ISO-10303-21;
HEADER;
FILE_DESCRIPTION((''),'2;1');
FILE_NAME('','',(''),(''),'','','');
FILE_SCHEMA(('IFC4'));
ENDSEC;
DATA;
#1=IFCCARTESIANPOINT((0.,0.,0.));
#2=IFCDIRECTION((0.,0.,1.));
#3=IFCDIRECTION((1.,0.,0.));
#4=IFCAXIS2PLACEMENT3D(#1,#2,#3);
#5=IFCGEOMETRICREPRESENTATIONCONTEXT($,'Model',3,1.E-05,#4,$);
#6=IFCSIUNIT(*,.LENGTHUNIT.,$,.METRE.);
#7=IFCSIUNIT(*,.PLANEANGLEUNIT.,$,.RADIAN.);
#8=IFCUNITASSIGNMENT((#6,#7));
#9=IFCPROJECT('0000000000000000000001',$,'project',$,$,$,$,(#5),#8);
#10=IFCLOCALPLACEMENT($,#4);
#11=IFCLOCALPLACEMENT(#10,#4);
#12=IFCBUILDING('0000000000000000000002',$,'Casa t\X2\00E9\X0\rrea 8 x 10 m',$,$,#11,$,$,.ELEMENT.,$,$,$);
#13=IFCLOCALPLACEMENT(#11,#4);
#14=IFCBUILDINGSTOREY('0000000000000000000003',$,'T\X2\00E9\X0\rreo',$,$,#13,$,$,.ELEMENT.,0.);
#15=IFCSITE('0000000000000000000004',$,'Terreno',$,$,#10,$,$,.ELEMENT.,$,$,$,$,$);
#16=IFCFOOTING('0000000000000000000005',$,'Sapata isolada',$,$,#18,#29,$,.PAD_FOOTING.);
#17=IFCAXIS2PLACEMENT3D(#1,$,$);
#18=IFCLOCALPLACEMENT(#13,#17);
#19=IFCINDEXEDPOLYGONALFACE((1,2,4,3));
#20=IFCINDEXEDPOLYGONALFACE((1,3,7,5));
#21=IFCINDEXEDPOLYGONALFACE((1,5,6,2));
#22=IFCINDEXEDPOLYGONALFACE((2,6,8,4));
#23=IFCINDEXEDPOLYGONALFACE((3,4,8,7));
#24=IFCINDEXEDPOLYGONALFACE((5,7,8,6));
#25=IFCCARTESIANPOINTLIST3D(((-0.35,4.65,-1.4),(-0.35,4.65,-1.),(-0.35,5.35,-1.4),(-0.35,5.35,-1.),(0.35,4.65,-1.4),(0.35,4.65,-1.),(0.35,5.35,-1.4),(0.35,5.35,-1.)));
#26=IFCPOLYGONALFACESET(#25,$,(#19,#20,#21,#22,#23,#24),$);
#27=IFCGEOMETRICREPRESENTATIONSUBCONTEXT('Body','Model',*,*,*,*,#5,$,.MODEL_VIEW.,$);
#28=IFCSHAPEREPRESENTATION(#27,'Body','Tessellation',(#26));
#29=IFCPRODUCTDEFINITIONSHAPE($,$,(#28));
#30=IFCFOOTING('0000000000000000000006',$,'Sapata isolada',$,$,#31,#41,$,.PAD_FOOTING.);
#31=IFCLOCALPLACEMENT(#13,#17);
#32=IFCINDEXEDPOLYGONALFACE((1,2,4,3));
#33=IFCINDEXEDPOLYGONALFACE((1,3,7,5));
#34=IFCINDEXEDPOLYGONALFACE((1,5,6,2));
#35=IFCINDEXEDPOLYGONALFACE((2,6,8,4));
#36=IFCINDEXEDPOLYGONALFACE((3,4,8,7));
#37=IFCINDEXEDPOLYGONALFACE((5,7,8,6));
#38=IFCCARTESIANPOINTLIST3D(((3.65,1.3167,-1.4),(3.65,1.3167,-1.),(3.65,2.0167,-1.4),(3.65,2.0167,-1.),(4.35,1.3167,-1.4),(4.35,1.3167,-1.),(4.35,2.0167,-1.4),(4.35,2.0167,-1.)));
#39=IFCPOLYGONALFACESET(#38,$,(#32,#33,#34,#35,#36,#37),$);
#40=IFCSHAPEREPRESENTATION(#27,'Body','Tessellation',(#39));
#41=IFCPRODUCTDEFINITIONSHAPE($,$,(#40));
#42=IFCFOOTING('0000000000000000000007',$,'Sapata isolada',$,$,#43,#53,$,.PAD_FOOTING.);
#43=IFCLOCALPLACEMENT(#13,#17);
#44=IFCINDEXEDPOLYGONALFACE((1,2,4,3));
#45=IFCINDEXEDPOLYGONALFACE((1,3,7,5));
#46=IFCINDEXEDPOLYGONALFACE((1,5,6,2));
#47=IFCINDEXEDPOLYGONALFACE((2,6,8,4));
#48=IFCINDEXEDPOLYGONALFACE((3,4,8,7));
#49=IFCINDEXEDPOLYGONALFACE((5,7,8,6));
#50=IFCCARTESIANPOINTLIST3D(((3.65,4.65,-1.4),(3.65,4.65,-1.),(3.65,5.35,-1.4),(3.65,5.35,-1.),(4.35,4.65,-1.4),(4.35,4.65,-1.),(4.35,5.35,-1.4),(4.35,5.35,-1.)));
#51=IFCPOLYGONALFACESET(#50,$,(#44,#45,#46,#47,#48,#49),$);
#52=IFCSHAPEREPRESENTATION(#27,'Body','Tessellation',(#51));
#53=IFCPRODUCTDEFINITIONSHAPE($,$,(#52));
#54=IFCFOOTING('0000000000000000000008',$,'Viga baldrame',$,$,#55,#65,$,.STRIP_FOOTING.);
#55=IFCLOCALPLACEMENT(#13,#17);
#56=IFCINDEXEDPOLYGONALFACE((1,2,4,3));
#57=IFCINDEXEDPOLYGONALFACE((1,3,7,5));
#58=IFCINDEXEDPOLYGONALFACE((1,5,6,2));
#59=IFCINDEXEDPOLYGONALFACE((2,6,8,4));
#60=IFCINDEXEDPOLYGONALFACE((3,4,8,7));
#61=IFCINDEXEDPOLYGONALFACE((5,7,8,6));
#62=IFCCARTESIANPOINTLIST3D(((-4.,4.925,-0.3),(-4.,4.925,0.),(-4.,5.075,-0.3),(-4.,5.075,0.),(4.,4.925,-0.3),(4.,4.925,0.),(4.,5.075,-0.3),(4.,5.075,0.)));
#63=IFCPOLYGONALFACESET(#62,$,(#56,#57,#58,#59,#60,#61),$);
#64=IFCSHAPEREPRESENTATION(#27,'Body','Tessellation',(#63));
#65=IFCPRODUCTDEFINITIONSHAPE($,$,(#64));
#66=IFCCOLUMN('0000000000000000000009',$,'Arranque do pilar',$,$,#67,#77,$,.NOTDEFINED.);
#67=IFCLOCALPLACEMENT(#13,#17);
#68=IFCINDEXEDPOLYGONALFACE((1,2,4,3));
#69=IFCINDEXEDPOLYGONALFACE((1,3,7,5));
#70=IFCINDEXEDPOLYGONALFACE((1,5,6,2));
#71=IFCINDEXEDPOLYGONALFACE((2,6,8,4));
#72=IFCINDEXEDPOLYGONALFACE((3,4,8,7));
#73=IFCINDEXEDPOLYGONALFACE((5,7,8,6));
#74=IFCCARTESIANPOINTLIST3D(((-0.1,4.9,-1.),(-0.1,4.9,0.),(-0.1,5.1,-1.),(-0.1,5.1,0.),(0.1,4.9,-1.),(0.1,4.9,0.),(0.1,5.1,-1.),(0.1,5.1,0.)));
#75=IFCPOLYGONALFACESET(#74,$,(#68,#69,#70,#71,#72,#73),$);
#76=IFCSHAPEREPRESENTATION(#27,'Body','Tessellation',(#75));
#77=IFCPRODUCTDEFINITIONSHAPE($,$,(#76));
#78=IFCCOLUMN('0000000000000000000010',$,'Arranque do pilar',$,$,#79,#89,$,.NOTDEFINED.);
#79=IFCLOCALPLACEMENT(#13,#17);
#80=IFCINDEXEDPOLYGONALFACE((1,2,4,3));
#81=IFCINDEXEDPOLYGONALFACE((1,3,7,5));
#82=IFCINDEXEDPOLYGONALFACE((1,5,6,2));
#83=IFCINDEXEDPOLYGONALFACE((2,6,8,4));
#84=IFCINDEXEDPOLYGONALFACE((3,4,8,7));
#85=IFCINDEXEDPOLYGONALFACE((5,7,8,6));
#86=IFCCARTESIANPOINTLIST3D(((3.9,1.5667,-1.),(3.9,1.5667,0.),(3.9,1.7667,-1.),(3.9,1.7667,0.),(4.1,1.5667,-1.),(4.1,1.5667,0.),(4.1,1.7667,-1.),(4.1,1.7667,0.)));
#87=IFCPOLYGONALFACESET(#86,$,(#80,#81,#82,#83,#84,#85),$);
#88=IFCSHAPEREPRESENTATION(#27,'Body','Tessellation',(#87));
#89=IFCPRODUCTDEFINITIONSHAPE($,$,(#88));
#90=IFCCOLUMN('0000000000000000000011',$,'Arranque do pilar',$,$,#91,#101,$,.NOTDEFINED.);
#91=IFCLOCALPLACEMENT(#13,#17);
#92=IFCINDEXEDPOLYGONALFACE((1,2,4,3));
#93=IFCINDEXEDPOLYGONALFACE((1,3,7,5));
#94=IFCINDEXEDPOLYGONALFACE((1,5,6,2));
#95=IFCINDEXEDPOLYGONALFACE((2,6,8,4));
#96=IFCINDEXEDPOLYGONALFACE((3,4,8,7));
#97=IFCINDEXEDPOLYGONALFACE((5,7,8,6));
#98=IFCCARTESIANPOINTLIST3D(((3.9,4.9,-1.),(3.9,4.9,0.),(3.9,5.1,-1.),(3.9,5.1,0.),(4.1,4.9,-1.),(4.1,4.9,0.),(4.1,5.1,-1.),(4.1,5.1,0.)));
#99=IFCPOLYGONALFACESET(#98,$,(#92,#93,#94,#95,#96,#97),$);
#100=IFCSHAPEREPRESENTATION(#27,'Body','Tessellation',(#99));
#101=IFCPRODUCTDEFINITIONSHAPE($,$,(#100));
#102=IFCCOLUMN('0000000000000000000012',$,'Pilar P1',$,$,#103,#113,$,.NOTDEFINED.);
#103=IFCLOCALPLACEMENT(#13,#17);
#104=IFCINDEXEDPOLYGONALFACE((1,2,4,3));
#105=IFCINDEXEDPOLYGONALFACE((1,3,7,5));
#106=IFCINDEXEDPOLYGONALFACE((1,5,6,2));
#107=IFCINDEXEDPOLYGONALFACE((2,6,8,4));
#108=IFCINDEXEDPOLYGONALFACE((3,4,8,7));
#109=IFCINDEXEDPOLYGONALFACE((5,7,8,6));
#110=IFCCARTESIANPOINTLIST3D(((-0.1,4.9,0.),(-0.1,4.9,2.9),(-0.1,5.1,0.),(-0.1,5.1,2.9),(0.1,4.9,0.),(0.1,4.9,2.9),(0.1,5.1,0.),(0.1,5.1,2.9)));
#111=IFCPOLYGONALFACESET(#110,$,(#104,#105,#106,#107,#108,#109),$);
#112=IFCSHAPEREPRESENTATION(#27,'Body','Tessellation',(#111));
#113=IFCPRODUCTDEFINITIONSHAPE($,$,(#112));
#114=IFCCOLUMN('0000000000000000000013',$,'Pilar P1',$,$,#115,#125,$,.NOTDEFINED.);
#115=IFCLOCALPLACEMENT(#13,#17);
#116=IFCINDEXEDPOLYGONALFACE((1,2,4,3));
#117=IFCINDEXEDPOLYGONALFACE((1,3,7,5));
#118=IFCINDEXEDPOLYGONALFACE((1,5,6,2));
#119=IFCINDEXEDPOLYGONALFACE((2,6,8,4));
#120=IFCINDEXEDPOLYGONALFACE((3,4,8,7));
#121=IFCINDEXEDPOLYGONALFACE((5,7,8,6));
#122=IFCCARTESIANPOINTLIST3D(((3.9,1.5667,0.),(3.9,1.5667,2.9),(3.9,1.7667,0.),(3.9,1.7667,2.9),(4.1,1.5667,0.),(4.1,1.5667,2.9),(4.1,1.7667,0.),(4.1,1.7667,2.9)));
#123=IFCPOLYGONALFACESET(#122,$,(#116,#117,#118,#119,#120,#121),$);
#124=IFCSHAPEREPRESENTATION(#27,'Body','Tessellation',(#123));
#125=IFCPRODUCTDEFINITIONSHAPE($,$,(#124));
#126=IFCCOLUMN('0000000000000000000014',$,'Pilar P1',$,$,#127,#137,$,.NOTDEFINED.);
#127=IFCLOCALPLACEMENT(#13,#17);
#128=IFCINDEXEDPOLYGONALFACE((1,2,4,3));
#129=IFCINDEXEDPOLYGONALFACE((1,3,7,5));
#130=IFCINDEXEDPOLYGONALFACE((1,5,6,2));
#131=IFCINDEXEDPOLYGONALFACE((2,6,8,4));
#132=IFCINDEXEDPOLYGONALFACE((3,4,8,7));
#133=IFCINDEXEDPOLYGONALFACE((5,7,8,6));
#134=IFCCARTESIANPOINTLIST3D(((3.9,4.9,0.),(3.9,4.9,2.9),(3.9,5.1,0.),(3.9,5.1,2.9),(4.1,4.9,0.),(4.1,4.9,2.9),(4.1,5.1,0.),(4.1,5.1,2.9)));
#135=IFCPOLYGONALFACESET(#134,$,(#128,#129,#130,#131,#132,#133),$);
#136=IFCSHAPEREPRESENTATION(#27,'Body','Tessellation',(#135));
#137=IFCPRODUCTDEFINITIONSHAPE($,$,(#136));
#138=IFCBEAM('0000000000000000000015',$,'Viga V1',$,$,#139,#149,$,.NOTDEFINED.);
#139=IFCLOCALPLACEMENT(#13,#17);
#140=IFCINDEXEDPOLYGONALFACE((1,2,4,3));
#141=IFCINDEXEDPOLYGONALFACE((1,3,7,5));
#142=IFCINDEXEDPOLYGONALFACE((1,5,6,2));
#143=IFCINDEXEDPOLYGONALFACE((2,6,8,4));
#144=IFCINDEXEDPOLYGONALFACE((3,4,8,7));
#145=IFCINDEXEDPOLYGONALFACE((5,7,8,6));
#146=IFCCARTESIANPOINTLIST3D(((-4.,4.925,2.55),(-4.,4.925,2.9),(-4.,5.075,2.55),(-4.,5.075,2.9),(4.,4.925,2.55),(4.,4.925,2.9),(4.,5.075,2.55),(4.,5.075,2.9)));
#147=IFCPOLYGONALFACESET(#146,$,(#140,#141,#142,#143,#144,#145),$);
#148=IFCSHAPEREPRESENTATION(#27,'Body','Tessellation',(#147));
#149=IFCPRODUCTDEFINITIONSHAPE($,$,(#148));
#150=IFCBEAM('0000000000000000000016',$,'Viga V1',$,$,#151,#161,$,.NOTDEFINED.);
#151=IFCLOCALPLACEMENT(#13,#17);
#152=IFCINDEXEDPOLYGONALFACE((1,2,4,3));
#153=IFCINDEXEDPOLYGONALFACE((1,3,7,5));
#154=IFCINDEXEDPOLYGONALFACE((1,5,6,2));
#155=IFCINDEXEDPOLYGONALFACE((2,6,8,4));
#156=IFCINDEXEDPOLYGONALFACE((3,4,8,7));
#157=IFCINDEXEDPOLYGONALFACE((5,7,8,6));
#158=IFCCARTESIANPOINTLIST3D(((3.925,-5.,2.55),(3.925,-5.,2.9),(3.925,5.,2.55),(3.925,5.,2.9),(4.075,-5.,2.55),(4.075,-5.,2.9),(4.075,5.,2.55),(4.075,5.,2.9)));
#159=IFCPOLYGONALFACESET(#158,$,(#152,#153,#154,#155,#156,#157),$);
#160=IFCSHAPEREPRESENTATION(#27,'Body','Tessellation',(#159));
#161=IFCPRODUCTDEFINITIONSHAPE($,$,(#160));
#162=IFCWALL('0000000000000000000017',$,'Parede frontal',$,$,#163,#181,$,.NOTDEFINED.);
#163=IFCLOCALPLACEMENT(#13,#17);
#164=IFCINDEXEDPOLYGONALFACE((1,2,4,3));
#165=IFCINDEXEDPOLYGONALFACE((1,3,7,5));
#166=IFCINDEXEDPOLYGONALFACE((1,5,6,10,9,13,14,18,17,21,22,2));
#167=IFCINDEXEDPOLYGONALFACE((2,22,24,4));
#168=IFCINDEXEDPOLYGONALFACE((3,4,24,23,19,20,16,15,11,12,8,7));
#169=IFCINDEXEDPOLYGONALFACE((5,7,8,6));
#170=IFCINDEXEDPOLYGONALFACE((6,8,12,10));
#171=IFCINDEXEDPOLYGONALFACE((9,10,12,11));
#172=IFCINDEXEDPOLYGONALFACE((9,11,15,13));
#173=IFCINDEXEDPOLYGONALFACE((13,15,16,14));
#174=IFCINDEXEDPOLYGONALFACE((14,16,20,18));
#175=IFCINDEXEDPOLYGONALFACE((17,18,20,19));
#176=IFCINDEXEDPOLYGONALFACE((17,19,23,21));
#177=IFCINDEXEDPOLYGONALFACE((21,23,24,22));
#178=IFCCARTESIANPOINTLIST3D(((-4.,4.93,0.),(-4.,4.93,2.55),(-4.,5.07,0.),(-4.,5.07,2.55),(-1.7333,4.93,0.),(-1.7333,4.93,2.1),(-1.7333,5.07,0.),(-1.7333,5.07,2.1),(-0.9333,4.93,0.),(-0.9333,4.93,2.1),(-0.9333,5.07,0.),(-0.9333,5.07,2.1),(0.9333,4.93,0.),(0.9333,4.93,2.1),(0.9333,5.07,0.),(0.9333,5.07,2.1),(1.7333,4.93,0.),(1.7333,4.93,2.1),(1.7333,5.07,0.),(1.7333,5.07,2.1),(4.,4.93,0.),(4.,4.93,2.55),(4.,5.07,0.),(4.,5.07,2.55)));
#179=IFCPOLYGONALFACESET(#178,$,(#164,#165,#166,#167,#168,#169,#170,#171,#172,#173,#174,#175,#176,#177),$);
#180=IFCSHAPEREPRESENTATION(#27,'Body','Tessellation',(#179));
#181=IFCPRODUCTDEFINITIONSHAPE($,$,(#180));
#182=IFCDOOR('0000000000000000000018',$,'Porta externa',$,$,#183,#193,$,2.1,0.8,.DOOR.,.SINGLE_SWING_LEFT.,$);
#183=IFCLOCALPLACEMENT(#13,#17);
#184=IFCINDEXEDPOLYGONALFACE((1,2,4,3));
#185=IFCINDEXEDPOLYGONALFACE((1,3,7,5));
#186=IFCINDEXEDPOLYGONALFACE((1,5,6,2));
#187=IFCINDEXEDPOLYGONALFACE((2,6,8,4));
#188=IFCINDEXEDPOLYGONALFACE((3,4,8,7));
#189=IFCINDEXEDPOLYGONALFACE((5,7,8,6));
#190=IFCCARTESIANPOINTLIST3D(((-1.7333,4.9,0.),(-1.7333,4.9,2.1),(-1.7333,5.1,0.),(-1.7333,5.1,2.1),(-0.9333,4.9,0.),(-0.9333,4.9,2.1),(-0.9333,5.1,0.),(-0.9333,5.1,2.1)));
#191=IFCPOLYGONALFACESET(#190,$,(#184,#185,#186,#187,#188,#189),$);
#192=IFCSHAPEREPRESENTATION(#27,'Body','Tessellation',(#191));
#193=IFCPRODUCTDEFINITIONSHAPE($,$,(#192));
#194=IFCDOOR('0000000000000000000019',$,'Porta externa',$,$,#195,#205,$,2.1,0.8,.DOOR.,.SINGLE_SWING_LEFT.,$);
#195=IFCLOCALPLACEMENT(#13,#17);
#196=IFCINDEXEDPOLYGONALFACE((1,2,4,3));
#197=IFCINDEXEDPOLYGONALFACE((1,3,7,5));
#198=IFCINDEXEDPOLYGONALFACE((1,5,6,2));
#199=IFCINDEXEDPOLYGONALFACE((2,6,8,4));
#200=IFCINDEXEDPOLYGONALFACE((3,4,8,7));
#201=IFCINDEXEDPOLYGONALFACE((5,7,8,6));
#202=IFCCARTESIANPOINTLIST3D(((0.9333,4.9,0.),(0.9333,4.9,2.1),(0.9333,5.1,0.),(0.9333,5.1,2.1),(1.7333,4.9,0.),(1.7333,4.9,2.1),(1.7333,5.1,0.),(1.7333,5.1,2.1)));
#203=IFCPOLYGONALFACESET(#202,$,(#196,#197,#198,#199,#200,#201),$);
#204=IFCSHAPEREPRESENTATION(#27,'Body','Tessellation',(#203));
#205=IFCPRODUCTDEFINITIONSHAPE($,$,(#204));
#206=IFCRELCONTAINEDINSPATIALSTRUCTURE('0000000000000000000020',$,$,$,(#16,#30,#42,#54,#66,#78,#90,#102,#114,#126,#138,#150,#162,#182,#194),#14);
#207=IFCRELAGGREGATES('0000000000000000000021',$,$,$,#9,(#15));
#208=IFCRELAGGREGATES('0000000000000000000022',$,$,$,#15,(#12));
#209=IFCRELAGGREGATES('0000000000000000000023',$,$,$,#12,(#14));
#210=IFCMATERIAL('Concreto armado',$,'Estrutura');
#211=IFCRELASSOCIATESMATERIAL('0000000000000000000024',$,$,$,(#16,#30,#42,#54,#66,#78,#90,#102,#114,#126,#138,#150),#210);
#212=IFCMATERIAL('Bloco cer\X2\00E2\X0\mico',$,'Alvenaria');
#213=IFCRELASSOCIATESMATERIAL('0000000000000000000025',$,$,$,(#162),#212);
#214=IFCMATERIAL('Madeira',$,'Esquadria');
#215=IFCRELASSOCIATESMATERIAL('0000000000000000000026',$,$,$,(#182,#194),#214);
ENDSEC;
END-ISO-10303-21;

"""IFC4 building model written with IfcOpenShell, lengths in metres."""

from ifc_helpers import new_model, si_unit, frame, origin_with_axes, origin_2d, place, context, subcontext, project, spatial, rectangle, extrude, material, element, fill, save


model = new_model("IFC4")

# Units and contexts
model_context = context("Model", 3, precision=1e-05, world=origin_with_axes())
body_context = subcontext(model_context, "Body", "Model", "MODEL_VIEW")
ifc_project = project(units=[si_unit("LENGTHUNIT", "METRE"), si_unit("PLANEANGLEUNIT", "RADIAN")], contexts=[model_context])

# Site, building, storey
site_placement = place(None, origin_with_axes())
site = spatial("IfcSite", under=ifc_project, at=site_placement, Name="Terreno", CompositionType="ELEMENT")
building_placement = place(site_placement, origin_with_axes())
building = spatial("IfcBuilding", under=site, at=building_placement, Name="Casa térrea 8 x 10 m", CompositionType="ELEMENT")
storey_placement = place(building_placement, origin_with_axes())
storey = spatial("IfcBuildingStorey", under=building, at=storey_placement, Name="Térreo", CompositionType="ELEMENT", Elevation=0.0)

# Footings
ifc_material_1 = material(Name="Concreto armado", Category="Estrutura")
for number, where, z_axis, x_axis, name in (
    (1, (0.0, 5.0, -1.4), (0.0, 0.0, 1.0), (1.0, 0.0, 0.0), "Sapata isolada"),
    (2, (4.0, 1.6667, -1.4), (0.0, 0.0, 1.0), (1.0, 0.0, 0.0), "Sapata isolada"),
    (3, (4.0, 5.0, -1.4), (0.0, 0.0, 1.0), (1.0, 0.0, 0.0), "Sapata isolada"),
):
    element("IfcFooting", number, at=place(storey_placement, frame(where, z_axis=z_axis, x_axis=x_axis)), inside=storey, material=ifc_material_1, Name=name, PredefinedType="PAD_FOOTING", context=body_context, shape_type="SweptSolid", body=[
        extrude(rectangle(XDim=0.7, YDim=0.7, at=origin_2d()), None, (0.0, 0.0, 1.0), 0.4),
    ])
footing_placement = place(storey_placement, frame((0.0, 5.0, -0.3), z_axis=(0.0, 0.0, 1.0), x_axis=(1.0, 0.0, 0.0)))
element("IfcFooting", 4, at=footing_placement, inside=storey, material=ifc_material_1, Name="Viga baldrame", PredefinedType="STRIP_FOOTING", context=body_context, shape_type="SweptSolid", body=[
    extrude(rectangle(XDim=8.0, YDim=0.15, at=origin_2d()), None, (0.0, 0.0, 1.0), 0.3),
])

# Columns
for number, where, z_axis, x_axis, name in (
    (5, (0.0, 5.0, -1.0), (0.0, 0.0, 1.0), (1.0, 0.0, 0.0), "Arranque do pilar"),
    (6, (4.0, 1.6667, -1.0), (0.0, 0.0, 1.0), (1.0, 0.0, 0.0), "Arranque do pilar"),
    (7, (4.0, 5.0, -1.0), (0.0, 0.0, 1.0), (1.0, 0.0, 0.0), "Arranque do pilar"),
):
    element("IfcColumn", number, at=place(storey_placement, frame(where, z_axis=z_axis, x_axis=x_axis)), inside=storey, material=ifc_material_1, Name=name, PredefinedType="NOTDEFINED", context=body_context, shape_type="SweptSolid", body=[
        extrude(rectangle(XDim=0.2, YDim=0.2, at=origin_2d()), None, (0.0, 0.0, 1.0), 1.0),
    ])
for number, where, z_axis, x_axis, name in (
    (8, (0.0, 5.0, 0.0), (0.0, 0.0, 1.0), (1.0, 0.0, 0.0), "Pilar P1"),
    (9, (4.0, 1.6667, 0.0), (0.0, 0.0, 1.0), (1.0, 0.0, 0.0), "Pilar P1"),
    (10, (4.0, 5.0, 0.0), (0.0, 0.0, 1.0), (1.0, 0.0, 0.0), "Pilar P1"),
):
    element("IfcColumn", number, at=place(storey_placement, frame(where, z_axis=z_axis, x_axis=x_axis)), inside=storey, material=ifc_material_1, Name=name, PredefinedType="NOTDEFINED", context=body_context, shape_type="SweptSolid", body=[
        extrude(rectangle(XDim=0.2, YDim=0.2, at=origin_2d()), None, (0.0, 0.0, 1.0), 2.9),
    ])

# Beams
beam_1_placement = place(storey_placement, frame((0.0, 5.0, 2.55), z_axis=(0.0, 0.0, 1.0), x_axis=(1.0, 0.0, 0.0)))
element("IfcBeam", 11, at=beam_1_placement, inside=storey, material=ifc_material_1, Name="Viga V1", PredefinedType="NOTDEFINED", context=body_context, shape_type="SweptSolid", body=[
    extrude(rectangle(XDim=8.0, YDim=0.15, at=origin_2d()), None, (0.0, 0.0, 1.0), 0.35),
])
beam_2_placement = place(storey_placement, frame((4.0, 0.0, 2.55), z_axis=(0.0, 0.0, 1.0), x_axis=(1.0, 0.0, 0.0)))
element("IfcBeam", 12, at=beam_2_placement, inside=storey, material=ifc_material_1, Name="Viga V1", PredefinedType="NOTDEFINED", context=body_context, shape_type="SweptSolid", body=[
    extrude(rectangle(XDim=0.15, YDim=10.0, at=origin_2d()), None, (0.0, 0.0, 1.0), 0.35),
])

# Wall, openings, doors
ifc_material_2 = material(Name="Bloco cerâmico", Category="Alvenaria")
wall_1_placement = place(storey_placement, frame((0.0, 5.0, 0.0), z_axis=(0.0, 0.0, 1.0), x_axis=(1.0, 0.0, 0.0)))
wall_1 = element("IfcWall", 13, at=wall_1_placement, inside=storey, material=ifc_material_2, Name="Parede frontal", PredefinedType="NOTDEFINED", context=body_context, shape_type="SweptSolid", body=[
    extrude(rectangle(XDim=8.0, YDim=0.14, at=origin_2d()), None, (0.0, 0.0, 1.0), 2.55),
])
opening_1_placement = place(storey_placement, frame((-1.3333, 5.0, 0.0), z_axis=(0.0, 0.0, 1.0), x_axis=(1.0, 0.0, 0.0)))
opening_1 = element("IfcOpeningElement", 14, at=opening_1_placement, cuts=wall_1, PredefinedType="OPENING", context=body_context, shape_type="SweptSolid", body=[
    extrude(rectangle(XDim=0.8, YDim=0.4, at=origin_2d()), None, (0.0, 0.0, 1.0), 2.1),
])
opening_2_placement = place(storey_placement, frame((1.3333, 5.0, 0.0), z_axis=(0.0, 0.0, 1.0), x_axis=(1.0, 0.0, 0.0)))
opening_2 = element("IfcOpeningElement", 15, at=opening_2_placement, cuts=wall_1, PredefinedType="OPENING", context=body_context, shape_type="SweptSolid", body=[
    extrude(rectangle(XDim=0.8, YDim=0.4, at=origin_2d()), None, (0.0, 0.0, 1.0), 2.1),
])
ifc_material_3 = material(Name="Madeira", Category="Esquadria")
door_1_placement = place(storey_placement, frame((-1.3333, 5.0, 0.0), z_axis=(0.0, 0.0, 1.0), x_axis=(1.0, 0.0, 0.0)))
door_1 = element("IfcDoor", 16, at=door_1_placement, inside=storey, material=ifc_material_3, Name="Porta externa", OperationType="SINGLE_SWING_LEFT", OverallHeight=2.1, OverallWidth=0.8, PredefinedType="DOOR", context=body_context, shape_type="SweptSolid", body=[
    extrude(rectangle(XDim=0.8, YDim=0.2, at=origin_2d()), None, (0.0, 0.0, 1.0), 2.1),
])
fill(opening_1, door_1)
door_2_placement = place(storey_placement, frame((1.3333, 5.0, 0.0), z_axis=(0.0, 0.0, 1.0), x_axis=(1.0, 0.0, 0.0)))
door_2 = element("IfcDoor", 17, at=door_2_placement, inside=storey, material=ifc_material_3, Name="Porta externa", OperationType="SINGLE_SWING_LEFT", OverallHeight=2.1, OverallWidth=0.8, PredefinedType="DOOR", context=body_context, shape_type="SweptSolid", body=[
    extrude(rectangle(XDim=0.8, YDim=0.2, at=origin_2d()), None, (0.0, 0.0, 1.0), 2.1),
])
fill(opening_2, door_2)

save(model, "model.ifc")
